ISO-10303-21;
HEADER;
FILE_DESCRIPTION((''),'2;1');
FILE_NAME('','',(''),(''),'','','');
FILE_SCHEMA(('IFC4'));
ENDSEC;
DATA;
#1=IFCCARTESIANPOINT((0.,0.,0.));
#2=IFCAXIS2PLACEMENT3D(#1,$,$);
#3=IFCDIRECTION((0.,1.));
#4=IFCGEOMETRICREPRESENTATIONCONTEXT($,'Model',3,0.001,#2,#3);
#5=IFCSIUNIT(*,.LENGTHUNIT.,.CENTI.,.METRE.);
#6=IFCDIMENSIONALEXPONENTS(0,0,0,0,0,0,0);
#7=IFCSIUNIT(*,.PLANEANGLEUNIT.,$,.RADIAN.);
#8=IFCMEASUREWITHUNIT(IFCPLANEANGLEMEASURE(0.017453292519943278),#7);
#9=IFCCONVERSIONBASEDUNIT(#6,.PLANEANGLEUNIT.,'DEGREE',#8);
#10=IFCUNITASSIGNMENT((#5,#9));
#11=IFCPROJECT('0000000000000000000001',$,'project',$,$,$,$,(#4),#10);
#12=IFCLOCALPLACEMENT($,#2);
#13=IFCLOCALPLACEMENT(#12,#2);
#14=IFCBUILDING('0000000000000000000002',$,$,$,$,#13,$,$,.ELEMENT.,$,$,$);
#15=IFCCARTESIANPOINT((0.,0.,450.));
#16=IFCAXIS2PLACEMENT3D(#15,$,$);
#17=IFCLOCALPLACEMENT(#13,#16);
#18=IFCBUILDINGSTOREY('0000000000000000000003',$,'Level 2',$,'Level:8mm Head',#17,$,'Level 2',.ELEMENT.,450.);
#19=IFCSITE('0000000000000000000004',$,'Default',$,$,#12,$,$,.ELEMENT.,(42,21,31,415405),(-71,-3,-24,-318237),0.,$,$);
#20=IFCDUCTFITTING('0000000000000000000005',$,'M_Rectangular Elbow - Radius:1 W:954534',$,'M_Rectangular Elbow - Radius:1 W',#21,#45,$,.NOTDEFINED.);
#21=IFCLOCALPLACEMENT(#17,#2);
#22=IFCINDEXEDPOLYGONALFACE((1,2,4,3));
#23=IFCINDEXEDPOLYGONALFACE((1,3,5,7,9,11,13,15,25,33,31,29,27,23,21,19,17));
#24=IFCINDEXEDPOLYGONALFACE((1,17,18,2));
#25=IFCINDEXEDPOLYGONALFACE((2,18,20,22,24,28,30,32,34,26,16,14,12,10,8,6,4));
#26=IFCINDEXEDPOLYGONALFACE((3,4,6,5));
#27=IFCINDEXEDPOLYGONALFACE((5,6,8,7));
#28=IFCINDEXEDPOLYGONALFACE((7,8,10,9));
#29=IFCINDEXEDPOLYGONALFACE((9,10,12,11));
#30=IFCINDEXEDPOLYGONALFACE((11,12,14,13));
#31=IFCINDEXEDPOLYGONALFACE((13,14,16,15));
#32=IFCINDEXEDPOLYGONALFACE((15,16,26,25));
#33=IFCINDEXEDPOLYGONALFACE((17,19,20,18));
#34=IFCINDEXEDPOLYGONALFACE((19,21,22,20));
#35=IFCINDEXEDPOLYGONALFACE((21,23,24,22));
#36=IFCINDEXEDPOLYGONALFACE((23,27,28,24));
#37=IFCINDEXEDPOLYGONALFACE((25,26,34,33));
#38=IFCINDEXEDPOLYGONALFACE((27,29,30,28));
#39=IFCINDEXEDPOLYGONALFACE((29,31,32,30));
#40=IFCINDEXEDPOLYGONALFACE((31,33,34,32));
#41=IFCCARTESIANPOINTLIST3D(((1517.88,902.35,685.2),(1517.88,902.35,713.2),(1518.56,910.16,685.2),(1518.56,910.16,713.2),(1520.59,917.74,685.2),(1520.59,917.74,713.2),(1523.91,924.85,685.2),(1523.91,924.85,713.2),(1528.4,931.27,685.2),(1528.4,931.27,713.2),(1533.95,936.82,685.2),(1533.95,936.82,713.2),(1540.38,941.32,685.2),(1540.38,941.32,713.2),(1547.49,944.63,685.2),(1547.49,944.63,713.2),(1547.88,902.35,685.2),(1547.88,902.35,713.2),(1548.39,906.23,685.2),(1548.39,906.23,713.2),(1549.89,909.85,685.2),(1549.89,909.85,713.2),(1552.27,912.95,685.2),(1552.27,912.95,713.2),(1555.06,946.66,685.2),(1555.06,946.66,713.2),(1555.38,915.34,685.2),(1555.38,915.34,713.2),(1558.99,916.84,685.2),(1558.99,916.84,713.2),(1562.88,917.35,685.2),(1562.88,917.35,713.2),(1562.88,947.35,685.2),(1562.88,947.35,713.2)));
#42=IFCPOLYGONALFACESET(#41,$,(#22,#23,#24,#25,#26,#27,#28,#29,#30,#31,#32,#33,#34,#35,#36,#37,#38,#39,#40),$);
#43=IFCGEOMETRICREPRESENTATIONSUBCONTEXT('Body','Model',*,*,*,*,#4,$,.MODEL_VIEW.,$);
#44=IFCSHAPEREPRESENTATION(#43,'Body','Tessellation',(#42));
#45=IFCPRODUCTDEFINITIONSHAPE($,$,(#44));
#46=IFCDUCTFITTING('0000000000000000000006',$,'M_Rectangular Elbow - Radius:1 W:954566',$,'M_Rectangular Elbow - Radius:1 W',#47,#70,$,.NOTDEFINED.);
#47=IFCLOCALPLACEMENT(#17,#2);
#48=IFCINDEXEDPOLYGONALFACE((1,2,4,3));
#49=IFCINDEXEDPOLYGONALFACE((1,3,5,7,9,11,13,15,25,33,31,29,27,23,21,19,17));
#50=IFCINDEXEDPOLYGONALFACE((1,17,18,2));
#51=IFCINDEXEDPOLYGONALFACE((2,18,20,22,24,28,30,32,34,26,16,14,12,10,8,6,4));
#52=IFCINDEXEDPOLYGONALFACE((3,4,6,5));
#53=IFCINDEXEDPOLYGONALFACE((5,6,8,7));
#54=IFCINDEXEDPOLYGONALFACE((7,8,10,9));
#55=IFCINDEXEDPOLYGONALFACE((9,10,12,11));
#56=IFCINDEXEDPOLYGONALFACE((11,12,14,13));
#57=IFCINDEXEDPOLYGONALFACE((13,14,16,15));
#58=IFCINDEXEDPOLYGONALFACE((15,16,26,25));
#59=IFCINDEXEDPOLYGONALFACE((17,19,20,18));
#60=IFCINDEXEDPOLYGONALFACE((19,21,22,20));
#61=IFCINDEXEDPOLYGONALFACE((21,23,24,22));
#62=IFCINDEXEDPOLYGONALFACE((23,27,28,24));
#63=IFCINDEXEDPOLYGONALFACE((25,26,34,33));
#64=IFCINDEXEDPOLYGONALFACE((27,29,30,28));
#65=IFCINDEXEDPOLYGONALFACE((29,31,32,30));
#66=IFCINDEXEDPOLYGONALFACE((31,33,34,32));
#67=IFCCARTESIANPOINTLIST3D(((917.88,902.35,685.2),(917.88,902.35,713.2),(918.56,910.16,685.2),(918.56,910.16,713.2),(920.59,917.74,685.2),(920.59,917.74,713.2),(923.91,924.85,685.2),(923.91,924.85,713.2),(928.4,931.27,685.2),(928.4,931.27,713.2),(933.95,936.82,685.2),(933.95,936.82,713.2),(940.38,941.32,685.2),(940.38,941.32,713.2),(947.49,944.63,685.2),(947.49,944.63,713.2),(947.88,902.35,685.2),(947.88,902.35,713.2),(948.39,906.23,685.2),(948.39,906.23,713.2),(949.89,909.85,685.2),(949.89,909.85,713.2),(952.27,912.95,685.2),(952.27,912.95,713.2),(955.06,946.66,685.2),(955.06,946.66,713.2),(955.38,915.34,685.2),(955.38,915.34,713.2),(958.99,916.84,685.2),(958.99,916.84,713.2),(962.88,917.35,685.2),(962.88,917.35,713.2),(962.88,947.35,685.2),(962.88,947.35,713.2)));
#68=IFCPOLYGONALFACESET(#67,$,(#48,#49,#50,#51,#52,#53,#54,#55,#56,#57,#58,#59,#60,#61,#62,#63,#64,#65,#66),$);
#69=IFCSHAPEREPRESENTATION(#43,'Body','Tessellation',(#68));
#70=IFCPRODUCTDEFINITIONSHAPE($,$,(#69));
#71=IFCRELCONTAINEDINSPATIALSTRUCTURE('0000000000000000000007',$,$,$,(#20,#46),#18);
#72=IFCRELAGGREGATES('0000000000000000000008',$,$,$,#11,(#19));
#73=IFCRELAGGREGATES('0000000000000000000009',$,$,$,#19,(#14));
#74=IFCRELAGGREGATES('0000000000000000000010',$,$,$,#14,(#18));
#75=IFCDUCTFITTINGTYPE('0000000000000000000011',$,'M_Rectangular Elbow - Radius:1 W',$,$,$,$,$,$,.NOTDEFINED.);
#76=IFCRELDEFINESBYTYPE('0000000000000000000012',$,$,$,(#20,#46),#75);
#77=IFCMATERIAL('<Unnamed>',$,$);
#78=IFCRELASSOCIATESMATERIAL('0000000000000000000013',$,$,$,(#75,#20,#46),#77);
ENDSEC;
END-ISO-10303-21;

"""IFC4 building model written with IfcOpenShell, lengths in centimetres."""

from ifc_helpers import new_model, entity, si_unit, converted_unit, direction, frame, origin, place, context, subcontext, project, spatial, line, arc, indexed_curve, outline, extrude, source, transform, mapped, material, type_object, type_shapes, element, save


model = new_model("IFC4")

# Units and contexts
model_context = context("Model", 3, precision=0.001, world=origin(), true_north=direction((0.0, 1.0)))
body_context = subcontext(model_context, "Body", "Model", "MODEL_VIEW")
ifc_project = project(units=[si_unit("LENGTHUNIT", "METRE", prefix="CENTI"), converted_unit("PLANEANGLEUNIT", "DEGREE", entity("IfcPlaneAngleMeasure", 0.017453292519943278), si_unit("PLANEANGLEUNIT", "RADIAN"), dimensions=[0, 0, 0, 0, 0, 0, 0])], contexts=[model_context])

# Site, building, storey
site_placement = place(None, origin())
site = spatial("IfcSite", under=ifc_project, at=site_placement, Name="Default", CompositionType="ELEMENT", RefLatitude=(42, 21, 31, 415405), RefLongitude=(-71, -3, -24, -318237), RefElevation=0.0)
building_placement = place(site_placement, origin())
building = spatial("IfcBuilding", under=site, at=building_placement, CompositionType="ELEMENT")
storey_placement = place(building_placement, frame((0.0, 0.0, 450.0)))
storey = spatial("IfcBuildingStorey", under=building, at=storey_placement, Name="Level 2", ObjectType="Level:8mm Head", LongName="Level 2", CompositionType="ELEMENT", Elevation=450.0)

# Duct fittings
ifc_material = material(Name="<Unnamed>")
duct_fitting_type_1 = type_object("IfcDuctFittingType", Name="M_Rectangular Elbow - Radius:1 W", PredefinedType="NOTDEFINED", material=ifc_material)
shared_shape_1 = source(origin(), body_context, "Body", "SweptSolid", [
    extrude(outline(indexed_curve([(-15.0, -30.0), (16.82, -16.82), (30.0, 15.0), (0.0, 15.0), (-4.39, 4.39), (-15.0, 0.0)], segments=[arc(1, 2, 3), line(3, 4), arc(4, 5, 6), line(6, 1)], self_intersect=False)), frame((-15.0, -15.0, -14.0), z_axis=(0.0, 0.0, 1.0), x_axis=(0.0, 1.0, 0.0)), (0.0, 0.0, 1.0), 28.0),
])
type_shapes(duct_fitting_type_1, [shared_shape_1])
for number, where, z_axis, x_axis, name in (
    (1, (1532.88, 932.35, 699.2), (0.0, 0.0, 1.0), (0.0, 1.0, 0.0), "M_Rectangular Elbow - Radius:1 W:954534"),
    (2, (932.88, 932.35, 699.2), (0.0, 0.0, 1.0), (0.0, 1.0, 0.0), "M_Rectangular Elbow - Radius:1 W:954566"),
):
    element("IfcDuctFitting", number, at=place(storey_placement, frame(where, z_axis=z_axis, x_axis=x_axis)), inside=storey, type_object=duct_fitting_type_1, material=ifc_material, Name=name, ObjectType="M_Rectangular Elbow - Radius:1 W", PredefinedType="NOTDEFINED", context=body_context, shape_type="MappedRepresentation", body=[
        mapped(shared_shape_1, transform((0.0, 0.0, 0.0), scale=1.0)),
    ])

save(model, "model.ifc")
